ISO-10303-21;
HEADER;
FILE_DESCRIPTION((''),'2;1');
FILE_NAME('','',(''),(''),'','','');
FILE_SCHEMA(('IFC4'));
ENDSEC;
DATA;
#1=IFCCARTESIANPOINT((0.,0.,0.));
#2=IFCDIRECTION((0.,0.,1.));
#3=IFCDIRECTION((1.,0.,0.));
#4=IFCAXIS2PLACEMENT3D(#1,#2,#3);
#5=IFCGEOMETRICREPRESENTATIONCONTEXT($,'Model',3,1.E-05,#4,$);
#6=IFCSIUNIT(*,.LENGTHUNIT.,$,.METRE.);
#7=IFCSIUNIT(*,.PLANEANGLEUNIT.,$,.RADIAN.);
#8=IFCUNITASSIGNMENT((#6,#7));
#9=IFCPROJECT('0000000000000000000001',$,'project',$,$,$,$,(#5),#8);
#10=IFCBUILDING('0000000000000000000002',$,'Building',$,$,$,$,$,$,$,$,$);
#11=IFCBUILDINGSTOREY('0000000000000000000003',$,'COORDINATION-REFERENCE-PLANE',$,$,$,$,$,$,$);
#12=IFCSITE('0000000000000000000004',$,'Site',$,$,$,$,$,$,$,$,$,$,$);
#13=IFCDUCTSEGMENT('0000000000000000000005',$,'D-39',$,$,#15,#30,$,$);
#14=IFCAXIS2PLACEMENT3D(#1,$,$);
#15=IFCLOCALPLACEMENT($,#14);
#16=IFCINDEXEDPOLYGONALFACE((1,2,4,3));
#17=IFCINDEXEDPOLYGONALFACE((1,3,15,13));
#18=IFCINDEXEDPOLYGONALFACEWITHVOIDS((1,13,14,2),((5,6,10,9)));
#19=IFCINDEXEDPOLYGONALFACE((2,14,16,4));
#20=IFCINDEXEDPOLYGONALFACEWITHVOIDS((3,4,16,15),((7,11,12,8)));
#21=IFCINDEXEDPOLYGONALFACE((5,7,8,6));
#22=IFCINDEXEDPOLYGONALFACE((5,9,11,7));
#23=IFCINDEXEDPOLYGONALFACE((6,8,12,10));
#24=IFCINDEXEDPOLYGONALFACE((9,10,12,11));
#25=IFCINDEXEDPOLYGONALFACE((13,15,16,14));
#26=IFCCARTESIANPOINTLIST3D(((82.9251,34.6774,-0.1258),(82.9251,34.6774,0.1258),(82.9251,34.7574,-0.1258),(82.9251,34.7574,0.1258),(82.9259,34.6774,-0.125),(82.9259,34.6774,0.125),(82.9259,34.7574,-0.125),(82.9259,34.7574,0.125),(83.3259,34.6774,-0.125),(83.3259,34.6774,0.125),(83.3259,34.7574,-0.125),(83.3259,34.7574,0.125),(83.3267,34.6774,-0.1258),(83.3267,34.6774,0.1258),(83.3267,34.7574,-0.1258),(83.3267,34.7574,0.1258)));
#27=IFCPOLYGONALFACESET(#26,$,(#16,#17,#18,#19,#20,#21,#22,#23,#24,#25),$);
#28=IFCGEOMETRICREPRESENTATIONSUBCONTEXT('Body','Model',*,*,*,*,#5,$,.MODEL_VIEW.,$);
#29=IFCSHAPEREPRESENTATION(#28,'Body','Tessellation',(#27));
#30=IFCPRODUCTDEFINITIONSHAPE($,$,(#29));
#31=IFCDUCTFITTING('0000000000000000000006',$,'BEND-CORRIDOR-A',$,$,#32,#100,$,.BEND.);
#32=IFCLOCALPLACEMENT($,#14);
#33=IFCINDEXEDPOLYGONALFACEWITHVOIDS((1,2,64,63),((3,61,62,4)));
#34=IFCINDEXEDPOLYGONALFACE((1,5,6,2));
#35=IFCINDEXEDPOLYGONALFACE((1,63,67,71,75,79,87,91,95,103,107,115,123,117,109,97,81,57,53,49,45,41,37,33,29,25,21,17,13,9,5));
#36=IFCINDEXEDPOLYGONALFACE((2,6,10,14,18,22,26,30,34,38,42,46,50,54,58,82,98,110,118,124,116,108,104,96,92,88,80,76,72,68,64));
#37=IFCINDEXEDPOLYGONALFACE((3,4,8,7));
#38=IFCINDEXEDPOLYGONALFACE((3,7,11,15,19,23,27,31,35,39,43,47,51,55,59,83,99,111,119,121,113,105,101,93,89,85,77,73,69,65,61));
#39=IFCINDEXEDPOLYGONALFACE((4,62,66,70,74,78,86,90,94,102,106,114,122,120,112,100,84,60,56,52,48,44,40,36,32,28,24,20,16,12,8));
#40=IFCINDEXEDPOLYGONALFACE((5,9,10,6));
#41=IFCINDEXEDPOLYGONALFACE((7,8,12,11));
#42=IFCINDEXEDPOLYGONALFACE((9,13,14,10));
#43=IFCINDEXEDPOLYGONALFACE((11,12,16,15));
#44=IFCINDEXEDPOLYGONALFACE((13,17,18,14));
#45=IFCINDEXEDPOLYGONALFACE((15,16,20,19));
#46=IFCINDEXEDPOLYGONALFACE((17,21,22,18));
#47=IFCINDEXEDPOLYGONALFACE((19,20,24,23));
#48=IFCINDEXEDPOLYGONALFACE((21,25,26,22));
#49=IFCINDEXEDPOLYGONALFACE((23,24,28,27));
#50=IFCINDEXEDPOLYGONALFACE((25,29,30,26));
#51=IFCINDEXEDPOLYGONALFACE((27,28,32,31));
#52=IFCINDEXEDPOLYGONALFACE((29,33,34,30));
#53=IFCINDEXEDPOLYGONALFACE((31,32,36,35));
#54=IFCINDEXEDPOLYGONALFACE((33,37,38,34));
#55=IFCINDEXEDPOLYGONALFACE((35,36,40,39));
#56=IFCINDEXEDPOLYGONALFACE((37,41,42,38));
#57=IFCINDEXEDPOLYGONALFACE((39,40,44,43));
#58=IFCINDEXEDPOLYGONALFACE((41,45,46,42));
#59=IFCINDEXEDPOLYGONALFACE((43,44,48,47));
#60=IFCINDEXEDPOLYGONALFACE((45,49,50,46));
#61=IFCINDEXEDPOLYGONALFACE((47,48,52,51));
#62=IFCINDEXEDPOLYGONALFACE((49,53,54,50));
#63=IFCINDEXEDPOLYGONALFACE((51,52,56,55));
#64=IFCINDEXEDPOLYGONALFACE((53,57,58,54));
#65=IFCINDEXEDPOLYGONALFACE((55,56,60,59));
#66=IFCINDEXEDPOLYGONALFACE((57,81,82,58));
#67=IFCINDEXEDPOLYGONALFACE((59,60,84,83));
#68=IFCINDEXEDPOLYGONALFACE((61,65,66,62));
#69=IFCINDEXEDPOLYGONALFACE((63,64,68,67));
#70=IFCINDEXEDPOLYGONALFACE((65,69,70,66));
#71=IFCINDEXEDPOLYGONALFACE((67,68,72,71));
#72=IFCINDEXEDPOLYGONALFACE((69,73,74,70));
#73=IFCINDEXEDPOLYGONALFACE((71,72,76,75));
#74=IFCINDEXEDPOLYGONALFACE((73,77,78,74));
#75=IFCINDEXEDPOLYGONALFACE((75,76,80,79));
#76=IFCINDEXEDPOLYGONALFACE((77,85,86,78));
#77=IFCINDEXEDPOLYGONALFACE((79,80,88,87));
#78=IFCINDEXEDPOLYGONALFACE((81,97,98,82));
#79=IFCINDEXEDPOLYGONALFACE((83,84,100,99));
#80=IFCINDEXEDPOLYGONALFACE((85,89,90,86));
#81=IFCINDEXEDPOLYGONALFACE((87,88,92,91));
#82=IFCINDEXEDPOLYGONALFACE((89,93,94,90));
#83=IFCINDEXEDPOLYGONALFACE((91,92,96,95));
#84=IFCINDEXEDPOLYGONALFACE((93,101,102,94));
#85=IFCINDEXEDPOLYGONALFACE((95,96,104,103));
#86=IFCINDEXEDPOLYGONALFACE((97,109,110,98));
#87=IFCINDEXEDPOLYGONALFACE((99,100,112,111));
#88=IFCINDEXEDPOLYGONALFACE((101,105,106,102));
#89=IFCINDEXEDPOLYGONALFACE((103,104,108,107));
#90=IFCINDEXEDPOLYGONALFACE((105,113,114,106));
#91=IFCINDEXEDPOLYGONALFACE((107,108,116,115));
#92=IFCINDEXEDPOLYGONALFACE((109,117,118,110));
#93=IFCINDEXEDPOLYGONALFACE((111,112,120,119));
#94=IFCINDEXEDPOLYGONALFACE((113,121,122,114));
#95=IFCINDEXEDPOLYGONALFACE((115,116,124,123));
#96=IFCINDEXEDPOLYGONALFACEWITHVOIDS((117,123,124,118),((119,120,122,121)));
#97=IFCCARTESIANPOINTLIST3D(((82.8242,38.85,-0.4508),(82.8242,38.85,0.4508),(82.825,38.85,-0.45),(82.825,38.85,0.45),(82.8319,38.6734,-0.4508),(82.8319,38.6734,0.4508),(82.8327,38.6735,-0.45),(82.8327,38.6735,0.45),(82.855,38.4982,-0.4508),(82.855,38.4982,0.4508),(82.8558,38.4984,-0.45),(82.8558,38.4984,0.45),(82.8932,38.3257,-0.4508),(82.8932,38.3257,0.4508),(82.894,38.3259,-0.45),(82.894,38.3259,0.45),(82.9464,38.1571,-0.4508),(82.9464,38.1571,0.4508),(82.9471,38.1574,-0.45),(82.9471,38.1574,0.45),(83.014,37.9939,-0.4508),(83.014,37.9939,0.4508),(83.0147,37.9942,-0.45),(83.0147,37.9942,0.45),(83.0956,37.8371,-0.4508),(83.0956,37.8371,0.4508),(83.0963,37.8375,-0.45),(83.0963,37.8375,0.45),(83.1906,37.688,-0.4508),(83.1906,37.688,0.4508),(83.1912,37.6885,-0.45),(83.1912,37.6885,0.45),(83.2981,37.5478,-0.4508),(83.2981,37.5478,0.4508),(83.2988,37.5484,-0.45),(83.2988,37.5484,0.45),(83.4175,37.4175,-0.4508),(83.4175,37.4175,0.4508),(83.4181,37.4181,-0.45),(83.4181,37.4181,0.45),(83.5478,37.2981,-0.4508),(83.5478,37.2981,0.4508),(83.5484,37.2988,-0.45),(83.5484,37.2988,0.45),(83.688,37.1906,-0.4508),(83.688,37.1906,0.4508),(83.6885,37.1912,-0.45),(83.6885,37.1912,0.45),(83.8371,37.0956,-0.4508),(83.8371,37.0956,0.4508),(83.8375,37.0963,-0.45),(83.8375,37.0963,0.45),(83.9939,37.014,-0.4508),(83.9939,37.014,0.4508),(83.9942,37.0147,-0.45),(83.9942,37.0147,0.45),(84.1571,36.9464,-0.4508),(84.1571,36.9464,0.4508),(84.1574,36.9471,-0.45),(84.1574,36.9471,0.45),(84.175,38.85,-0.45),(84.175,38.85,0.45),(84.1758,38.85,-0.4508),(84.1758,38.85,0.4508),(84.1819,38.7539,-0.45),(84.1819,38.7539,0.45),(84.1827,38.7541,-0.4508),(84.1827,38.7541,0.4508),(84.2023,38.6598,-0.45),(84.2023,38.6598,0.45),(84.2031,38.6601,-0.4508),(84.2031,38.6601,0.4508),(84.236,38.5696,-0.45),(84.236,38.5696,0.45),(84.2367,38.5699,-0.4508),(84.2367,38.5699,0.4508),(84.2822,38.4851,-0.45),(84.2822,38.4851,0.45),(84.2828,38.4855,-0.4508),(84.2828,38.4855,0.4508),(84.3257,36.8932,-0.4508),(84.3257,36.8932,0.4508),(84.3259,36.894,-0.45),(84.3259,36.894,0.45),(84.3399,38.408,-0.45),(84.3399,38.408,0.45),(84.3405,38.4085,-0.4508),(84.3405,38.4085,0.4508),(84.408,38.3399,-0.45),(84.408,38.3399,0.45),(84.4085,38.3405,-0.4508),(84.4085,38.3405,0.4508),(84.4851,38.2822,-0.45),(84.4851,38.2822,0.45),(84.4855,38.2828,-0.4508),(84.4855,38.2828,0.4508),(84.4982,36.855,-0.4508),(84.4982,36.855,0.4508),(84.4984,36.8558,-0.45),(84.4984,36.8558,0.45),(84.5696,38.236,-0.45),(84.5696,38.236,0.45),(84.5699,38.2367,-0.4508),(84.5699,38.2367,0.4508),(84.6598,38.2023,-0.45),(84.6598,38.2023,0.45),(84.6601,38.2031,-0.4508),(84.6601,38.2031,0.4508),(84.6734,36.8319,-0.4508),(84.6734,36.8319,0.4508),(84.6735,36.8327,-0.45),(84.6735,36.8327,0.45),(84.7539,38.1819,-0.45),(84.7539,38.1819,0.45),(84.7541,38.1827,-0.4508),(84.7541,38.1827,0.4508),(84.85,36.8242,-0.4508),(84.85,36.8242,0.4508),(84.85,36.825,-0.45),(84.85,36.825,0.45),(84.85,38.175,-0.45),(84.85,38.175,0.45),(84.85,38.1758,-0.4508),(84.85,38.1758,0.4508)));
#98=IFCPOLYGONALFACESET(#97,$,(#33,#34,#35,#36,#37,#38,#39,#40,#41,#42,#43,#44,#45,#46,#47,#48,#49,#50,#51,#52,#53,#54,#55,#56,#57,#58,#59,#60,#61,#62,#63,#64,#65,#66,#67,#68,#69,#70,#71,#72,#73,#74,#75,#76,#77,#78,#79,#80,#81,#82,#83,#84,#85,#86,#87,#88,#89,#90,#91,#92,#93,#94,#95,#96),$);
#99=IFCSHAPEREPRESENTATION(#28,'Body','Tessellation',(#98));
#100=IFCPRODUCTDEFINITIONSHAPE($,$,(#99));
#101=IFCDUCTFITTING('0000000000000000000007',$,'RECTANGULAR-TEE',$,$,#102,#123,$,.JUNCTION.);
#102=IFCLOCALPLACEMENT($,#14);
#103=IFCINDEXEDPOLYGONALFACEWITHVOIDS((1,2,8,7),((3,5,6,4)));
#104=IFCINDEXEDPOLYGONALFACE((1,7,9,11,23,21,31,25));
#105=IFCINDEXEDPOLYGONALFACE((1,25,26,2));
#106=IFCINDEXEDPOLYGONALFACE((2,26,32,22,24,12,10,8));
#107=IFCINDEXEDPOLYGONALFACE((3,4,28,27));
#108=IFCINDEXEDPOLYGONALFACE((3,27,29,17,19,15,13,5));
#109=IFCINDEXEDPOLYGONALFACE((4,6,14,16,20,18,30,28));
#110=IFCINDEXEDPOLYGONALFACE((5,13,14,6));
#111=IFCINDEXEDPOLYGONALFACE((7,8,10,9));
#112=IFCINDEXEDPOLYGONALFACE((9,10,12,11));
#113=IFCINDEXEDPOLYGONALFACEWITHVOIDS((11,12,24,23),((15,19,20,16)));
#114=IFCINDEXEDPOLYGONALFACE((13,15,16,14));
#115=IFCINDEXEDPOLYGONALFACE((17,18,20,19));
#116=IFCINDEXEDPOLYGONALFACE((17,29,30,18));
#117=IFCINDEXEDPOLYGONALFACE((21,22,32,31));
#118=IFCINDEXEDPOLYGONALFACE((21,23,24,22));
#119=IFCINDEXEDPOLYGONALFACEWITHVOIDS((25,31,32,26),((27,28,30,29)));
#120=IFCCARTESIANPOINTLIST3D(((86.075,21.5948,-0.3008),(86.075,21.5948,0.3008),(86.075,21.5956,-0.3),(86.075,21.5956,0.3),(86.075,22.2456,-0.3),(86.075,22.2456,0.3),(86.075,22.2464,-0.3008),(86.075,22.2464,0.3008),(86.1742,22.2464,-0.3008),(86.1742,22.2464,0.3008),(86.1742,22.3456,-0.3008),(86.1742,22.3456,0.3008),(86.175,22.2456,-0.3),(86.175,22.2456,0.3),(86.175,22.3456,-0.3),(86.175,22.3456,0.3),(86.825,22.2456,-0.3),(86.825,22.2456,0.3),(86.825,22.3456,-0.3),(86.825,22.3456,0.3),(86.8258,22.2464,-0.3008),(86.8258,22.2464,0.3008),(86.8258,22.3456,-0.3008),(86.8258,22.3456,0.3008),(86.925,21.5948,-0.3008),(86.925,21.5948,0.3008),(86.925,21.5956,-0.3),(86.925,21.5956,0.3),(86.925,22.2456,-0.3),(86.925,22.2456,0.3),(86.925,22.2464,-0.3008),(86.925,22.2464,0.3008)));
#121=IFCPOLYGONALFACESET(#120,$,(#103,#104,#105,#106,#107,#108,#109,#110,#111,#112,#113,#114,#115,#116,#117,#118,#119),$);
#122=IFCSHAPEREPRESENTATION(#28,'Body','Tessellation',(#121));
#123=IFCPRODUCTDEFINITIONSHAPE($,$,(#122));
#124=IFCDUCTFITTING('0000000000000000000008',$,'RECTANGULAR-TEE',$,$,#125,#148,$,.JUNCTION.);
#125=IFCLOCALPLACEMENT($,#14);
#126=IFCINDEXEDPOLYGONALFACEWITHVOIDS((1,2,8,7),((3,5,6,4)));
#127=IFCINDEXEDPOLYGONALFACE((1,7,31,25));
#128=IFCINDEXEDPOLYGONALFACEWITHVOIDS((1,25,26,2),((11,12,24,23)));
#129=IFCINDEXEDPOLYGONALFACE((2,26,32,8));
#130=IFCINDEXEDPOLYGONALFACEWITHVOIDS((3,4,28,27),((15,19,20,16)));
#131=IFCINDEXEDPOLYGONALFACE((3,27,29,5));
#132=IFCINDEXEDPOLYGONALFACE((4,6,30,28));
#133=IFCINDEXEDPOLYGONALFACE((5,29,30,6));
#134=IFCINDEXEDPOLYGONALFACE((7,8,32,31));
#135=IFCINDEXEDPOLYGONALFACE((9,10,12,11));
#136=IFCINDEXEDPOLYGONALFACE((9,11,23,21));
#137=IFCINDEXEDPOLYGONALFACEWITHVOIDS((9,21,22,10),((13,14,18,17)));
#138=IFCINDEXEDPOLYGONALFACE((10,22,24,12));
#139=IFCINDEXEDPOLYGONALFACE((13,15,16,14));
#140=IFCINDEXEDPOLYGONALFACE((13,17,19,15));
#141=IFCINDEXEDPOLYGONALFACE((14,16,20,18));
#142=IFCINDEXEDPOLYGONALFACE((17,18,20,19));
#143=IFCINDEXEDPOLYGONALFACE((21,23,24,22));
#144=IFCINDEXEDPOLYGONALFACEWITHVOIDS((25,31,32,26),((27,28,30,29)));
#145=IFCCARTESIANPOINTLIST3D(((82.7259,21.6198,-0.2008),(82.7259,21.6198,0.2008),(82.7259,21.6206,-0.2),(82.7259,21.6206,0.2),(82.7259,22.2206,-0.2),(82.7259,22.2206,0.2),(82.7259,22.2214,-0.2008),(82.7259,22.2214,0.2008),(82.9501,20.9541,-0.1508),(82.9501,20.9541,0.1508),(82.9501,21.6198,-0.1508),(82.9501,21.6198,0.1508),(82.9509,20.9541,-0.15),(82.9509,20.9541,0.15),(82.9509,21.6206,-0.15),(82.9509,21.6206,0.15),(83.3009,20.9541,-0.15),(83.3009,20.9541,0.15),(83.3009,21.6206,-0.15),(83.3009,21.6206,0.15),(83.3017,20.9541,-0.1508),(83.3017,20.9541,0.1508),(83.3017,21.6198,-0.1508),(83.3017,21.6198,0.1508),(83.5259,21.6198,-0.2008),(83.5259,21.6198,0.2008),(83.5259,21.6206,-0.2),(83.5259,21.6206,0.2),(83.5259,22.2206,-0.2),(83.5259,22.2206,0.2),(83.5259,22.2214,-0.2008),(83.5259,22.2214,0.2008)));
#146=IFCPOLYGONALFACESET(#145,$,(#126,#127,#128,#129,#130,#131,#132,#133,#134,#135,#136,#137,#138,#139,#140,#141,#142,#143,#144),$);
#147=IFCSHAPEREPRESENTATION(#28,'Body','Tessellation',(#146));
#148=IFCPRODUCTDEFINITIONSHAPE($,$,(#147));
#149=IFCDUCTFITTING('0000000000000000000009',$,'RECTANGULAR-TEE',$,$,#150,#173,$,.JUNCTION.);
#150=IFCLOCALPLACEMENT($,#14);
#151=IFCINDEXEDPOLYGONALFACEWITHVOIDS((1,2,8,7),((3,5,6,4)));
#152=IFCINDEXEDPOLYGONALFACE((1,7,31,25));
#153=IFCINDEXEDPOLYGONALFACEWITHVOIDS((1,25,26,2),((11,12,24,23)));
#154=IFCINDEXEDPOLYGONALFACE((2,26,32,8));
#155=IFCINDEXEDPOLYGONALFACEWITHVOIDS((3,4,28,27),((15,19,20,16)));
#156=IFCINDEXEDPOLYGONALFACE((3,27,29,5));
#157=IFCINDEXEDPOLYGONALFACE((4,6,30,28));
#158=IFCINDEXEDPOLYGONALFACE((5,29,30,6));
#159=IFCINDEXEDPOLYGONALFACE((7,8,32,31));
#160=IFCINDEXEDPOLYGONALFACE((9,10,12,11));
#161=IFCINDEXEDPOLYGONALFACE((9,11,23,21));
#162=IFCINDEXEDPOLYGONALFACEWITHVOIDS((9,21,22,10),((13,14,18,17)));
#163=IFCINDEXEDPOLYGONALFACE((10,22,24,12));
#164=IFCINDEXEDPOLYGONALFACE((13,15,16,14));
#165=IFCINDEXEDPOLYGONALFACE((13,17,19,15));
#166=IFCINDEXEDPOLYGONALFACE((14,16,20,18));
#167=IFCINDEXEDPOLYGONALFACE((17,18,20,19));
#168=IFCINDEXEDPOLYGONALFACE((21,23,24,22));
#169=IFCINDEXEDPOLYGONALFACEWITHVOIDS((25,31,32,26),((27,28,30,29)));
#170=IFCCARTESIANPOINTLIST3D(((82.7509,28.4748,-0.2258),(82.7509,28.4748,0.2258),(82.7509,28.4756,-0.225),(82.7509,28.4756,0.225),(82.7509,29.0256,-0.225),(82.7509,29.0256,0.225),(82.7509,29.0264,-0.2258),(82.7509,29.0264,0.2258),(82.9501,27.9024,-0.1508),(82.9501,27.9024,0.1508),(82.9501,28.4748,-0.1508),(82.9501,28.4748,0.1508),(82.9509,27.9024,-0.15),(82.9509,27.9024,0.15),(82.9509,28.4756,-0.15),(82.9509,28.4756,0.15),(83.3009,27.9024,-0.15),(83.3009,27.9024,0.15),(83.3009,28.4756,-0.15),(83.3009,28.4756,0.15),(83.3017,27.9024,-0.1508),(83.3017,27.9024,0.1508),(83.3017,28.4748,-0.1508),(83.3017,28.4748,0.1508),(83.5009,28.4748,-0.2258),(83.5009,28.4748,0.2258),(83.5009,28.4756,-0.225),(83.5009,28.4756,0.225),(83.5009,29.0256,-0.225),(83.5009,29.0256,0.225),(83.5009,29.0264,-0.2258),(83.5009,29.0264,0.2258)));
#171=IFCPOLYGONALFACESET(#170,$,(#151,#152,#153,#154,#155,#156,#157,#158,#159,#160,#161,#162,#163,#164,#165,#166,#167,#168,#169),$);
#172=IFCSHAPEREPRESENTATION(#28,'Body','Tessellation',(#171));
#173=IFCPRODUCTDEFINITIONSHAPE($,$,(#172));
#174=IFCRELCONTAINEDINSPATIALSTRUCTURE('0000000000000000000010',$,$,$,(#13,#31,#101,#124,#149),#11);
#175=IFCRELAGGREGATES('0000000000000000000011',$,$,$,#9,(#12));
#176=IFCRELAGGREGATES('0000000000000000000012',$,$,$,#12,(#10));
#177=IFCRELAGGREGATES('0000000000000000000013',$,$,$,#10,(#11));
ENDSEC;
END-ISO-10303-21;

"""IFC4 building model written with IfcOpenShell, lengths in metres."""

from ifc_helpers import new_model, entity, si_unit, frame, origin, origin_with_axes, place, context, subcontext, project, spatial, rectangle, hollow_rectangle, extrude, boolean, element, save


model = new_model("IFC4")

# Units and contexts
model_context = context("Model", 3, precision=1e-05, world=origin_with_axes())
body_context_1 = subcontext(model_context, "Body", "Model", "MODEL_VIEW")
ifc_project = project(units=[si_unit("LENGTHUNIT", "METRE"), si_unit("PLANEANGLEUNIT", "RADIAN")], contexts=[model_context])

# Site, building, storey
site = spatial("IfcSite", under=ifc_project, Name="Site")
building = spatial("IfcBuilding", under=site, Name="Building")
storey = spatial("IfcBuildingStorey", under=building, Name="COORDINATION-REFERENCE-PLANE")

# Duct segment
duct_segment_1_placement = place(None, frame((83.1259, 34.6774, 0.0), z_axis=(0.0, 1.0, 0.0), x_axis=(1.0, 0.0, 0.0)))
element("IfcDuctSegment", 1, at=duct_segment_1_placement, inside=storey, Name="D-39", context=body_context_1, shape_type="SweptSolid", body=[
    extrude(hollow_rectangle(XDim=0.4016, YDim=0.2516, WallThickness=0.0008), origin(), (0.0, 0.0, 1.0), 0.08),
])

# Duct fittings
duct_fitting_1_placement = place(None, frame((84.85, 38.85, 0.0), z_axis=(0.0, 0.0, 1.0), x_axis=(-1.0, 0.0, 0.0)))
cartesian_point_1 = entity("IfcCartesianPoint", [0.0, 0.0, 0.0])
element("IfcDuctFitting", 2, at=duct_fitting_1_placement, inside=storey, Name="BEND-CORRIDOR-A", PredefinedType="BEND", context=body_context_1, shape_type="SweptSolid", body=[
    entity("IfcRevolvedAreaSolid", entity("IfcRectangleHollowProfileDef", "AREA", None, entity("IfcAxis2Placement2D", entity("IfcCartesianPoint", [1.35, 0.0])), 1.3516, 0.9016, 0.0008), entity("IfcAxis2Placement3D", cartesian_point_1, entity("IfcDirection", [0.0, -1.0, 0.0]), entity("IfcDirection", [1.0, 0.0, 0.0])), entity("IfcAxis1Placement", cartesian_point_1, entity("IfcDirection", [0.0, 1.0, 0.0])), 1.570796),
])
duct_fitting_2_placement = place(None, frame((86.5, 21.9206, 0.0), z_axis=(1.0, 0.0, 0.0), x_axis=(0.0, 1.0, 0.0)))
solid_1 = boolean("UNION", extrude(rectangle(XDim=0.65, YDim=0.6), frame((0.0, 0.0, -0.425), z_axis=(0.0, 0.0, 1.0), x_axis=(1.0, 0.0, 0.0)), (0.0, 0.0, 1.0), 0.85), extrude(rectangle(XDim=0.65, YDim=0.6), frame((0.0, 0.0, 0.0), z_axis=(1.0, 0.0, 0.0), x_axis=(0.0, 0.0, -1.0)), (0.0, 0.0, 1.0), 0.425))
element("IfcDuctFitting", 3, at=duct_fitting_2_placement, inside=storey, Name="RECTANGULAR-TEE", PredefinedType="JUNCTION", context=body_context_1, shape_type="CSG", body=[
    boolean("DIFFERENCE", boolean("UNION", extrude(rectangle(XDim=0.6516, YDim=0.6016), frame((0.0, 0.0, -0.425), z_axis=(0.0, 0.0, 1.0), x_axis=(1.0, 0.0, 0.0)), (0.0, 0.0, 1.0), 0.85), extrude(rectangle(XDim=0.6516, YDim=0.6016), frame((0.0, 0.0, 0.0), z_axis=(1.0, 0.0, 0.0), x_axis=(0.0, 0.0, -1.0)), (0.0, 0.0, 1.0), 0.425)), solid_1),
])
duct_fitting_3_placement = place(None, frame((83.1259, 21.9206, 0.0), z_axis=(-1.0, 0.0, 0.0), x_axis=(0.0, -1.0, 0.0)))
solid_2 = boolean("UNION", extrude(rectangle(XDim=0.6, YDim=0.4), frame((0.0, 0.0, -0.4), z_axis=(0.0, 0.0, 1.0), x_axis=(1.0, 0.0, 0.0)), (0.0, 0.0, 1.0), 0.8), extrude(rectangle(XDim=0.35, YDim=0.3), frame((0.0, 0.0, 0.0), z_axis=(1.0, 0.0, 0.0), x_axis=(0.0, 0.0, -1.0)), (0.0, 0.0, 1.0), 0.9665))
element("IfcDuctFitting", 4, at=duct_fitting_3_placement, inside=storey, Name="RECTANGULAR-TEE", PredefinedType="JUNCTION", context=body_context_1, shape_type="CSG", body=[
    boolean("DIFFERENCE", boolean("UNION", extrude(rectangle(XDim=0.6016, YDim=0.4016), frame((0.0, 0.0, -0.4), z_axis=(0.0, 0.0, 1.0), x_axis=(1.0, 0.0, 0.0)), (0.0, 0.0, 1.0), 0.8), extrude(rectangle(XDim=0.3516, YDim=0.3016), frame((0.0, 0.0, 0.0), z_axis=(1.0, 0.0, 0.0), x_axis=(0.0, 0.0, -1.0)), (0.0, 0.0, 1.0), 0.9665)), solid_2),
])
duct_fitting_4_placement = place(None, frame((83.1259, 28.7506, 0.0), z_axis=(-1.0, 0.0, 0.0), x_axis=(0.0, -1.0, 0.0)))
solid_3 = boolean("UNION", extrude(rectangle(XDim=0.55, YDim=0.45), frame((0.0, 0.0, -0.375), z_axis=(0.0, 0.0, 1.0), x_axis=(1.0, 0.0, 0.0)), (0.0, 0.0, 1.0), 0.75), extrude(rectangle(XDim=0.35, YDim=0.3), frame((0.0, 0.0, 0.0), z_axis=(1.0, 0.0, 0.0), x_axis=(0.0, 0.0, -1.0)), (0.0, 0.0, 1.0), 0.8482))
element("IfcDuctFitting", 5, at=duct_fitting_4_placement, inside=storey, Name="RECTANGULAR-TEE", PredefinedType="JUNCTION", context=body_context_1, shape_type="CSG", body=[
    boolean("DIFFERENCE", boolean("UNION", extrude(rectangle(XDim=0.5516, YDim=0.4516), frame((0.0, 0.0, -0.375), z_axis=(0.0, 0.0, 1.0), x_axis=(1.0, 0.0, 0.0)), (0.0, 0.0, 1.0), 0.75), extrude(rectangle(XDim=0.3516, YDim=0.3016), frame((0.0, 0.0, 0.0), z_axis=(1.0, 0.0, 0.0), x_axis=(0.0, 0.0, -1.0)), (0.0, 0.0, 1.0), 0.8482)), solid_3),
])

save(model, "model.ifc")
